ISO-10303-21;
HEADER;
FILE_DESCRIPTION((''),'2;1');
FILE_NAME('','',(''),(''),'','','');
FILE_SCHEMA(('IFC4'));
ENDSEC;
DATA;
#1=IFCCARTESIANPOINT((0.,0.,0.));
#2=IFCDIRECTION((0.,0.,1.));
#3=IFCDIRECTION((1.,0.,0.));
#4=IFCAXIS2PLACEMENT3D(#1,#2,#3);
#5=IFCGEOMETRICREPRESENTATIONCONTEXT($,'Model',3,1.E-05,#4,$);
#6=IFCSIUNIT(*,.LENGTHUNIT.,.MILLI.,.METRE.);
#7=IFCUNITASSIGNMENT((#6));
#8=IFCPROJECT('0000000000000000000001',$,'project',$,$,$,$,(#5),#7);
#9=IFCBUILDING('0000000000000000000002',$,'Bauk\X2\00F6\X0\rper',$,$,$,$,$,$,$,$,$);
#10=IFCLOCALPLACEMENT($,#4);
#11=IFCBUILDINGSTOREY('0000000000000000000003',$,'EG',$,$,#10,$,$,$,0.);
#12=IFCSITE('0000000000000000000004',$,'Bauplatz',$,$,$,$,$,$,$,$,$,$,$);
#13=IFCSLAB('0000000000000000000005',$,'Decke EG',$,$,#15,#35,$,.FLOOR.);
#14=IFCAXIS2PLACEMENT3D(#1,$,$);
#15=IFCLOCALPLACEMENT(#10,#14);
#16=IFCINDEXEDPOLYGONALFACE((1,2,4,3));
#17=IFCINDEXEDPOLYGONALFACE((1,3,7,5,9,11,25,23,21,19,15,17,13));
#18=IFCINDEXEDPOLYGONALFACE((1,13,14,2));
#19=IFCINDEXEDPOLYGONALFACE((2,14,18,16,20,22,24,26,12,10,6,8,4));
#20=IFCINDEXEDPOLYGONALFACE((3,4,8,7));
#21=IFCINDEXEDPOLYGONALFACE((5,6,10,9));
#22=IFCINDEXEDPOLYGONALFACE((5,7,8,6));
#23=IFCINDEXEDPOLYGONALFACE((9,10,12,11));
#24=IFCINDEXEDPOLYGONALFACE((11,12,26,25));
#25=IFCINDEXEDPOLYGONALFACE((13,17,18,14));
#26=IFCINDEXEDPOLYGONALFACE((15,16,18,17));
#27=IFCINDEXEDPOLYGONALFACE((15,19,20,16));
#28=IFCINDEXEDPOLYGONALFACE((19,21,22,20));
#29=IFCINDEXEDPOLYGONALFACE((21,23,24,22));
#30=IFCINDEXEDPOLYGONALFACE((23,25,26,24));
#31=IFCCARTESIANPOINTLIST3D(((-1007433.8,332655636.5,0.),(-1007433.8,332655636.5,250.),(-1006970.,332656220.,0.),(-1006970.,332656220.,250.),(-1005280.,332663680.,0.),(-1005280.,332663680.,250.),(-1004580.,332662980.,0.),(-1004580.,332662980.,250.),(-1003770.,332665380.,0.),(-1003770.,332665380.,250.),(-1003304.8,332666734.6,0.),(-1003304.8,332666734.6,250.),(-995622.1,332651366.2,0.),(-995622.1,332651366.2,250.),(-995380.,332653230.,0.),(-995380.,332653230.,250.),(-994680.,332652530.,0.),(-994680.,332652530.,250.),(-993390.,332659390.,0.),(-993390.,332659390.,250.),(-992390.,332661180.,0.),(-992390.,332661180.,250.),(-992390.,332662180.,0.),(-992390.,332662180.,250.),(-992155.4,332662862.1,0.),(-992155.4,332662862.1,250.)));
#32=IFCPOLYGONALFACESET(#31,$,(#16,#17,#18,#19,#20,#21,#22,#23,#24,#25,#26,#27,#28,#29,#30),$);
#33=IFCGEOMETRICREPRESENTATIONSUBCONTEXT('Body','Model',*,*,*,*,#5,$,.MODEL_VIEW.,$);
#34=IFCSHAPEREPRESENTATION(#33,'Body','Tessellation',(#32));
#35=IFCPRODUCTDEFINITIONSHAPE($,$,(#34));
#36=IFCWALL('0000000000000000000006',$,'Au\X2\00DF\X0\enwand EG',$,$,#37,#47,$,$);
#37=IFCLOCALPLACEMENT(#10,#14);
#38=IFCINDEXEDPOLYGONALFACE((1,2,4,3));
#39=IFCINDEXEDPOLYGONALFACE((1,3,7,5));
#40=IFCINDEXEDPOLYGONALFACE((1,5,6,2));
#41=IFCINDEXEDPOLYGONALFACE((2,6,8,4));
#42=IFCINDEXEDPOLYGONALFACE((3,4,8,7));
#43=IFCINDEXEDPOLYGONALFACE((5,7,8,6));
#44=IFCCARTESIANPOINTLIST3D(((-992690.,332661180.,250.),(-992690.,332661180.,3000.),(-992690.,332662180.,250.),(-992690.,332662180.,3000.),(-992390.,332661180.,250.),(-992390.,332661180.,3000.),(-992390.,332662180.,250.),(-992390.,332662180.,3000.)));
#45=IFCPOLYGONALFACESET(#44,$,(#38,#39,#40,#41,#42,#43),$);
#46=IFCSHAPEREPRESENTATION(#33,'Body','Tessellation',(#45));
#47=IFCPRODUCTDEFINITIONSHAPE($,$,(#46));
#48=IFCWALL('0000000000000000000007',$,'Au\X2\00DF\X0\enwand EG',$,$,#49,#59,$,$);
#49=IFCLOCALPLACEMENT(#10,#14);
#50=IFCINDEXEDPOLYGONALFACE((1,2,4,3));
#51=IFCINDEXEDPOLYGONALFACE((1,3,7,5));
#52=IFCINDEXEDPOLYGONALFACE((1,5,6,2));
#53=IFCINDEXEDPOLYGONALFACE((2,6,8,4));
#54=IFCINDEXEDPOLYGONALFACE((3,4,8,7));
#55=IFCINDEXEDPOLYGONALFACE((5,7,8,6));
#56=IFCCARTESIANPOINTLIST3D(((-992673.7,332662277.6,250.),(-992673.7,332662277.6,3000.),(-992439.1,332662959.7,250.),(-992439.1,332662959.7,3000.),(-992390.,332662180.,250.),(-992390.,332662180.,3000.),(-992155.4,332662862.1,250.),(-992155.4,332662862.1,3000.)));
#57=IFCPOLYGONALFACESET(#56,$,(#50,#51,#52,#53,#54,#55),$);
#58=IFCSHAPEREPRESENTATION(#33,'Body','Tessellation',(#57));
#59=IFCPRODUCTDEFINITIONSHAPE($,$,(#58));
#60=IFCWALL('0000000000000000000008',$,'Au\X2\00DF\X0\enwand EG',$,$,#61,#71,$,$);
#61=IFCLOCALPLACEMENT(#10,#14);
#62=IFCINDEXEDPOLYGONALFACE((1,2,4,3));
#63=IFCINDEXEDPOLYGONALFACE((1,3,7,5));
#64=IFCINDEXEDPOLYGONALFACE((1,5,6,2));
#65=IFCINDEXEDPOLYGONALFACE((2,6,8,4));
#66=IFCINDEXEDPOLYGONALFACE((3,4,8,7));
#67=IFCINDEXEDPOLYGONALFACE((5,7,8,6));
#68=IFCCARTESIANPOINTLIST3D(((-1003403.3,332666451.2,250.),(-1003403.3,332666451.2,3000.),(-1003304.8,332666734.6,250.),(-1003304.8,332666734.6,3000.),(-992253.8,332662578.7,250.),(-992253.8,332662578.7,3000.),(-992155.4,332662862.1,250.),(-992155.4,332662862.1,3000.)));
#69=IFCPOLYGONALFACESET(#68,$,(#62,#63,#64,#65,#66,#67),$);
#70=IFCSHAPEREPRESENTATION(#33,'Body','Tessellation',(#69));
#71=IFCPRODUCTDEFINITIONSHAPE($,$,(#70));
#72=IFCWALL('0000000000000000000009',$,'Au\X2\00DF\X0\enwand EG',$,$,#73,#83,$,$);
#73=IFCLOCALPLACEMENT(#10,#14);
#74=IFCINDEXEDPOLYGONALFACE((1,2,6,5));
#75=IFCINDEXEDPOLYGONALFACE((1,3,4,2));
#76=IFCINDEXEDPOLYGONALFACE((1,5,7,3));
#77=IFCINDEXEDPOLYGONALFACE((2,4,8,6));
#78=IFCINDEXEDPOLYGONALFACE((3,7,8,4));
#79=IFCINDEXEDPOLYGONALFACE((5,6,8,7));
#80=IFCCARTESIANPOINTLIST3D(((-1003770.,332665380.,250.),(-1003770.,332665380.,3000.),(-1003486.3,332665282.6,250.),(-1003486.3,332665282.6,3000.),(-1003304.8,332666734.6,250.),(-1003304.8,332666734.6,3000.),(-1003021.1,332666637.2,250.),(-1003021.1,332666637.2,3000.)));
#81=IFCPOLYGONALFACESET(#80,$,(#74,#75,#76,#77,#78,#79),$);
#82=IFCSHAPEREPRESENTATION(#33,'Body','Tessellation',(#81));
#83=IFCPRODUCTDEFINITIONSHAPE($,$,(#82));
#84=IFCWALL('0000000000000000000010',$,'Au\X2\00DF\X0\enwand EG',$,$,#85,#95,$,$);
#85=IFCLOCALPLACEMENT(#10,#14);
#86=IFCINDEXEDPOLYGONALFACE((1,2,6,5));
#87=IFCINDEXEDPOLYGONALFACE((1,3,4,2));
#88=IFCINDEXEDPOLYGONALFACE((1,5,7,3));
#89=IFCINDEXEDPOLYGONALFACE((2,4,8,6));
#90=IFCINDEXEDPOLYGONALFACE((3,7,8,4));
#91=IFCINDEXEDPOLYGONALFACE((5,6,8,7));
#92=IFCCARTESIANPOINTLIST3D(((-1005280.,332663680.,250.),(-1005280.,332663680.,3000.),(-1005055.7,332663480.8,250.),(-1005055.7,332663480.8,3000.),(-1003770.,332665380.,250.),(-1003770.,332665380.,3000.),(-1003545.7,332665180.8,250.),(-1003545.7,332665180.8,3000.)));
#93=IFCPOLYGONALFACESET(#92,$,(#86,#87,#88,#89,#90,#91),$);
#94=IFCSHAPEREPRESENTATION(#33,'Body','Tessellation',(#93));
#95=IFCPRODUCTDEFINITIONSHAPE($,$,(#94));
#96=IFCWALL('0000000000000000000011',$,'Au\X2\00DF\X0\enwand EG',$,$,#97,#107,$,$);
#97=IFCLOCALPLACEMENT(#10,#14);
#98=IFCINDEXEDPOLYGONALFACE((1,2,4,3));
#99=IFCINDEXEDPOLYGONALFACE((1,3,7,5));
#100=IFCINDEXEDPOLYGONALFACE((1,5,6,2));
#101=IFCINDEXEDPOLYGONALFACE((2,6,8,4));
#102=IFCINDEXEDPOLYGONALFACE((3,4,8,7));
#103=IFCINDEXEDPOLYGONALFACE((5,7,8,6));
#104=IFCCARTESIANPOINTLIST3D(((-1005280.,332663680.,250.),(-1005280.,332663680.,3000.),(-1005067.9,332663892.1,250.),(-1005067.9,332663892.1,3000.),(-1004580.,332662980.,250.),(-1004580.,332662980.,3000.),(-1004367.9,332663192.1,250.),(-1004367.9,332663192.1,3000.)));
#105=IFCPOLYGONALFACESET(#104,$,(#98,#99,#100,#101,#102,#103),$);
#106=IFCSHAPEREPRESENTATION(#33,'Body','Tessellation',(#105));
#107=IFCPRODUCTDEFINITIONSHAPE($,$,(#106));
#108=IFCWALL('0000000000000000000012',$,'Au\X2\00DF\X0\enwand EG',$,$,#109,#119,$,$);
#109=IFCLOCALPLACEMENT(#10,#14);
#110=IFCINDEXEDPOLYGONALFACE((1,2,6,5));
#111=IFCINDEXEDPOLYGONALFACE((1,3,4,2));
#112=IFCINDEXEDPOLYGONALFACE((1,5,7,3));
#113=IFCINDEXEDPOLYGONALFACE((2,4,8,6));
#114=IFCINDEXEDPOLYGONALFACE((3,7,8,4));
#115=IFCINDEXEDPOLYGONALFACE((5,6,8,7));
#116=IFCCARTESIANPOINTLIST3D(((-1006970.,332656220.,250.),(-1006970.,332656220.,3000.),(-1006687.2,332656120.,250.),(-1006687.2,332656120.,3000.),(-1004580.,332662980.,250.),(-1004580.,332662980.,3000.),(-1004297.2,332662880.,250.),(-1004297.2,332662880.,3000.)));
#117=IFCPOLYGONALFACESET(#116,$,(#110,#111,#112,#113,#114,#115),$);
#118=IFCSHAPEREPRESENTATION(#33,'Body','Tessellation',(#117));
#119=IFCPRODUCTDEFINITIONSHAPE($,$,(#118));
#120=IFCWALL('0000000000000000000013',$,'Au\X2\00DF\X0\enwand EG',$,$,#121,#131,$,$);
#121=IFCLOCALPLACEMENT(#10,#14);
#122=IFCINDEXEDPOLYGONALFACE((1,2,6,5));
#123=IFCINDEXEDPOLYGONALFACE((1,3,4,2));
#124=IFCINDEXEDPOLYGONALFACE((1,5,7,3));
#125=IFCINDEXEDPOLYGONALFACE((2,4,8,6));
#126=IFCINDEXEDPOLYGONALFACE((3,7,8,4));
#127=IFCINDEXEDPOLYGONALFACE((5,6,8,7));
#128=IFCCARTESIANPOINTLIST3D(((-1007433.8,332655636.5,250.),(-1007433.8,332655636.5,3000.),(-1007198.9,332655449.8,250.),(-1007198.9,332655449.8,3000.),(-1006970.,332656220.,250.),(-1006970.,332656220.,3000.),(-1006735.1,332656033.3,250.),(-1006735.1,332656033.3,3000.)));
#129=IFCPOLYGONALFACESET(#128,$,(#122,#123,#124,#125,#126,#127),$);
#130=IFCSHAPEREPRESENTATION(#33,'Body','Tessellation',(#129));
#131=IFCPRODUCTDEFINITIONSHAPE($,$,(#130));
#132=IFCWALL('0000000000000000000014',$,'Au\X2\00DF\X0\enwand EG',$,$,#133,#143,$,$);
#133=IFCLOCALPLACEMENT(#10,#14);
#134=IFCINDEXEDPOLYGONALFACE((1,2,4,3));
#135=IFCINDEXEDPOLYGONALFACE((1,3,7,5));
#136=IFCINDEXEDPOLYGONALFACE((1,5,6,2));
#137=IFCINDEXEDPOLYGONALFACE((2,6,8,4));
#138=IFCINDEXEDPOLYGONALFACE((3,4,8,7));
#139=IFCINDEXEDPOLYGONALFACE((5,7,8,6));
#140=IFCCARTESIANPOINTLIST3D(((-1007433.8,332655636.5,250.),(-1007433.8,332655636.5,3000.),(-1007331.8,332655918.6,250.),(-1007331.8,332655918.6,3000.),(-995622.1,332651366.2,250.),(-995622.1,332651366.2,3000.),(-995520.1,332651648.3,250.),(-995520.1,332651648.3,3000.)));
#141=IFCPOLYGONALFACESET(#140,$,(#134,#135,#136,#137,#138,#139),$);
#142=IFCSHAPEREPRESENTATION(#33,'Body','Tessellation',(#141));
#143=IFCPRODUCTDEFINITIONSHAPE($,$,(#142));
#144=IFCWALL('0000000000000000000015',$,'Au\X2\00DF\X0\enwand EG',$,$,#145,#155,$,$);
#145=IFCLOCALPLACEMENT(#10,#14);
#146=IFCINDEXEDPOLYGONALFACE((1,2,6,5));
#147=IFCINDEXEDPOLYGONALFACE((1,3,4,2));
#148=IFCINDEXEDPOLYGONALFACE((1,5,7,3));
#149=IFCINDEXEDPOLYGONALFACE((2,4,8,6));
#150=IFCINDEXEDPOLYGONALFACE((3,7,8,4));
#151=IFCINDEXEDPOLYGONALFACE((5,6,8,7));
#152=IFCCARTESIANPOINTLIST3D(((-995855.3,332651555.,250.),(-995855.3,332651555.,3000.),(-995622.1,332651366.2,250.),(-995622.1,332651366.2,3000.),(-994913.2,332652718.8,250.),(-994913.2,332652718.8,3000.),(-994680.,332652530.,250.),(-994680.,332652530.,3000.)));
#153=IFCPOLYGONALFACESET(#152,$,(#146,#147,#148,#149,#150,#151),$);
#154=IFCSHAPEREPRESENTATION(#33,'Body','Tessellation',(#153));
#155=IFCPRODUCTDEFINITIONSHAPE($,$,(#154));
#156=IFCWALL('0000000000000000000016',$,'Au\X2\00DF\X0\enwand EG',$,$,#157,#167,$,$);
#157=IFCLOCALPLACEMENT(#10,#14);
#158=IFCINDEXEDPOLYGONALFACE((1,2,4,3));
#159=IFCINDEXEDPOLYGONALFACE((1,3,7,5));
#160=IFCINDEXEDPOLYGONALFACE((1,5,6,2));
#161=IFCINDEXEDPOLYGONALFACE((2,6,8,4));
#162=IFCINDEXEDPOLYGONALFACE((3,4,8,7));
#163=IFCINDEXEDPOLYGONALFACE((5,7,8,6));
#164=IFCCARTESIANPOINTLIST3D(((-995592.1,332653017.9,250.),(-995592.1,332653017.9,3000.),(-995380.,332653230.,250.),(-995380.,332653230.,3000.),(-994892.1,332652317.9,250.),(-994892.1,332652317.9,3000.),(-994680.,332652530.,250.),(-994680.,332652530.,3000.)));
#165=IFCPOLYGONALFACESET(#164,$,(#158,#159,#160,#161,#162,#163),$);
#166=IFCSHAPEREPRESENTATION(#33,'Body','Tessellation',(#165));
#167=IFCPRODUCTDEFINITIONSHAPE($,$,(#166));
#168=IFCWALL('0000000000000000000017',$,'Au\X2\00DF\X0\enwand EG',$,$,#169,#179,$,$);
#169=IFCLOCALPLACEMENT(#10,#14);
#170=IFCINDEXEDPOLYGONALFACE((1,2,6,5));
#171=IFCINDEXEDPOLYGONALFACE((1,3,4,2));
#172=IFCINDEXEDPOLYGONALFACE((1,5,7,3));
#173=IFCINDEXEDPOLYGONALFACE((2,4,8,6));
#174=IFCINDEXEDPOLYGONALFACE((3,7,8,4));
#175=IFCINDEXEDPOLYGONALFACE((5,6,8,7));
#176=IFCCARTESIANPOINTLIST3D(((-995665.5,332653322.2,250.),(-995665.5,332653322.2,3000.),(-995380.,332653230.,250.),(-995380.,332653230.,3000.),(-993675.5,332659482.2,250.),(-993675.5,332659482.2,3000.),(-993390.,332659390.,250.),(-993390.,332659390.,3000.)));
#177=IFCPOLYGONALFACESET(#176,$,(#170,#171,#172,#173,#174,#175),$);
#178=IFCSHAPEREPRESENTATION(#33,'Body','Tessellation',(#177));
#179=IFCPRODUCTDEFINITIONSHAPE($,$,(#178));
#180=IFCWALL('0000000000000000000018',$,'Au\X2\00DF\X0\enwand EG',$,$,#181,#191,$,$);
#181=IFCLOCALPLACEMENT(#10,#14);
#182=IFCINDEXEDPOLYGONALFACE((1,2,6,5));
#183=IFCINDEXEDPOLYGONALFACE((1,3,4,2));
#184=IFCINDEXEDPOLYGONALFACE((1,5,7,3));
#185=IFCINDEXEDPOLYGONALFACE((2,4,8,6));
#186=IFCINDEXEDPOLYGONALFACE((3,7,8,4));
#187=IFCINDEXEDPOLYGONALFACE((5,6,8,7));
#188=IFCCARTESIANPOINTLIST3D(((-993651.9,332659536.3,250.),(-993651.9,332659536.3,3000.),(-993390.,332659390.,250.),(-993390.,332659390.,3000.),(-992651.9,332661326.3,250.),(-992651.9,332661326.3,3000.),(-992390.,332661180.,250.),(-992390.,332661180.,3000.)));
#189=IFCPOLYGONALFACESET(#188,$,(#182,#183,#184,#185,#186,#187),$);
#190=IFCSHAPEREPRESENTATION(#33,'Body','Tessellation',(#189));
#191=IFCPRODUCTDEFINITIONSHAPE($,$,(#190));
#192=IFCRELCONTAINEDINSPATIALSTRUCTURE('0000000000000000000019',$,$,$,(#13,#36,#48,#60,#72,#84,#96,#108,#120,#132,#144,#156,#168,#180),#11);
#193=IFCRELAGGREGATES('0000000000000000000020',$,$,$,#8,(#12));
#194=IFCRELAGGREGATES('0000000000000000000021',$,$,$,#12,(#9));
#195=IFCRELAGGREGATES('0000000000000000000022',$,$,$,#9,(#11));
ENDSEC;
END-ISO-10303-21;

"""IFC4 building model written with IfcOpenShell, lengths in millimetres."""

from ifc_helpers import new_model, si_unit, frame, origin_with_axes, place, context, subcontext, project, spatial, indexed_curve, outline, extrude, element, save


model = new_model("IFC4")

# Units and contexts
model_context = context("Model", 3, precision=1e-05, world=origin_with_axes())
body_context = subcontext(model_context, "Body", "Model", "MODEL_VIEW")
ifc_project = project(units=[si_unit("LENGTHUNIT", "METRE", prefix="MILLI")], contexts=[model_context])

# Site, building, storey
site = spatial("IfcSite", under=ifc_project, Name="Bauplatz")
building = spatial("IfcBuilding", under=site, Name="Baukörper")
storey_placement = place(None, origin_with_axes())
storey = spatial("IfcBuildingStorey", under=building, at=storey_placement, Name="EG", Elevation=0.0)

# Slab
slab_placement = place(storey_placement, origin_with_axes())
element("IfcSlab", 1, at=slab_placement, inside=storey, Name="Decke EG", PredefinedType="FLOOR", context=body_context, shape_type="SweptSolid", body=[
    extrude(outline(indexed_curve([(-992390.0, 332661180.0), (-993390.0, 332659390.0), (-995380.0, 332653230.0), (-994680.0, 332652530.0), (-995622.1, 332651366.2), (-1007433.8, 332655636.5), (-1006970.0, 332656220.0), (-1004580.0, 332662980.0), (-1005280.0, 332663680.0), (-1003770.0, 332665380.0), (-1003304.8, 332666734.6), (-992155.4, 332662862.1), (-992390.0, 332662180.0)])), None, (0.0, 0.0, 1.0), 250.0),
])

# Walls
wall_1_placement = place(storey_placement, frame((-992390.0, 332661180.0, 250.0), z_axis=(0.0, 0.0, 1.0), x_axis=(0.0, 1.0, 0.0)))
element("IfcWall", 2, at=wall_1_placement, inside=storey, Name="Außenwand EG", context=body_context, shape_type="SweptSolid", body=[
    extrude(outline(indexed_curve([(0.0, 0.0), (0.0, 300.0), (1000.0, 300.0), (1000.0, 0.0), (0.0, 0.0)], self_intersect=False)), origin_with_axes(), (0.0, 0.0, 1.0), 2750.0),
])
wall_2_placement = place(storey_placement, frame((-992390.0, 332662180.0, 250.0), z_axis=(0.0, 0.0, 1.0), x_axis=(0.32522, 0.945639, 0.0)))
element("IfcWall", 3, at=wall_2_placement, inside=storey, Name="Außenwand EG", context=body_context, shape_type="SweptSolid", body=[
    extrude(outline(indexed_curve([(0.0, 0.0), (0.0, 300.0), (721.3, 300.0), (721.3, 0.0), (0.0, 0.0)], self_intersect=False)), origin_with_axes(), (0.0, 0.0, 1.0), 2750.0),
])
wall_3_placement = place(storey_placement, frame((-992155.4, 332662862.1, 250.0), z_axis=(0.0, 0.0, 1.0), x_axis=(-0.944643, 0.328101, 0.0)))
element("IfcWall", 4, at=wall_3_placement, inside=storey, Name="Außenwand EG", context=body_context, shape_type="SweptSolid", body=[
    extrude(outline(indexed_curve([(0.0, 0.0), (0.0, 300.0), (11802.8, 300.0), (11802.8, 0.0), (0.0, 0.0)], self_intersect=False)), origin_with_axes(), (0.0, 0.0, 1.0), 2750.0),
])
wall_4_placement = place(storey_placement, frame((-1003304.8, 332666734.6, 250.0), z_axis=(0.0, 0.0, 1.0), x_axis=(-0.324776, -0.945791, 0.0)))
element("IfcWall", 5, at=wall_4_placement, inside=storey, Name="Außenwand EG", context=body_context, shape_type="SweptSolid", body=[
    extrude(outline(indexed_curve([(0.0, 0.0), (0.0, 300.0), (1432.3, 300.0), (1432.3, 0.0), (0.0, 0.0)], self_intersect=False)), origin_with_axes(), (0.0, 0.0, 1.0), 2750.0),
])
wall_5_placement = place(storey_placement, frame((-1003770.0, 332665380.0, 250.0), z_axis=(0.0, 0.0, 1.0), x_axis=(-0.664091, -0.747652, 0.0)))
element("IfcWall", 6, at=wall_5_placement, inside=storey, Name="Außenwand EG", context=body_context, shape_type="SweptSolid", body=[
    extrude(outline(indexed_curve([(0.0, 0.0), (0.0, 300.0), (2273.8, 300.0), (2273.8, 0.0), (0.0, 0.0)], self_intersect=False)), origin_with_axes(), (0.0, 0.0, 1.0), 2750.0),
])
wall_6_placement = place(storey_placement, frame((-1005280.0, 332663680.0, 250.0), z_axis=(0.0, 0.0, 1.0), x_axis=(0.707107, -0.707107, 0.0)))
element("IfcWall", 7, at=wall_6_placement, inside=storey, Name="Außenwand EG", context=body_context, shape_type="SweptSolid", body=[
    extrude(outline(indexed_curve([(0.0, 0.0), (0.0, 300.0), (989.9, 300.0), (989.9, 0.0), (0.0, 0.0)], self_intersect=False)), origin_with_axes(), (0.0, 0.0, 1.0), 2750.0),
])
wall_7_placement = place(storey_placement, frame((-1004580.0, 332662980.0, 250.0), z_axis=(0.0, 0.0, 1.0), x_axis=(-0.333331, -0.94281, 0.0)))
element("IfcWall", 8, at=wall_7_placement, inside=storey, Name="Außenwand EG", context=body_context, shape_type="SweptSolid", body=[
    extrude(outline(indexed_curve([(0.0, 0.0), (0.0, 300.0), (7170.1, 300.0), (7170.1, 0.0), (0.0, 0.0)], self_intersect=False)), origin_with_axes(), (0.0, 0.0, 1.0), 2750.0),
])
wall_8_placement = place(storey_placement, frame((-1006970.0, 332656220.0, 250.0), z_axis=(0.0, 0.0, 1.0), x_axis=(-0.622179, -0.782875, 0.0)))
element("IfcWall", 9, at=wall_8_placement, inside=storey, Name="Außenwand EG", context=body_context, shape_type="SweptSolid", body=[
    extrude(outline(indexed_curve([(0.0, 0.0), (0.0, 300.0), (745.4, 300.0), (745.4, 0.0), (0.0, 0.0)], self_intersect=False)), origin_with_axes(), (0.0, 0.0, 1.0), 2750.0),
])
wall_9_placement = place(storey_placement, frame((-1007433.8, 332655636.5, 250.0), z_axis=(0.0, 0.0, 1.0), x_axis=(0.940428, -0.339993, 0.0)))
element("IfcWall", 10, at=wall_9_placement, inside=storey, Name="Außenwand EG", context=body_context, shape_type="SweptSolid", body=[
    extrude(outline(indexed_curve([(0.0, 0.0), (0.0, 300.0), (12559.9, 300.0), (12559.9, 0.0), (0.0, 0.0)], self_intersect=False)), origin_with_axes(), (0.0, 0.0, 1.0), 2750.0),
])
wall_10_placement = place(storey_placement, frame((-995622.1, 332651366.2, 250.0), z_axis=(0.0, 0.0, 1.0), x_axis=(0.629198, 0.777245, 0.0)))
element("IfcWall", 11, at=wall_10_placement, inside=storey, Name="Außenwand EG", context=body_context, shape_type="SweptSolid", body=[
    extrude(outline(indexed_curve([(0.0, 0.0), (0.0, 300.0), (1497.3, 300.0), (1497.3, 0.0), (0.0, 0.0)], self_intersect=False)), origin_with_axes(), (0.0, 0.0, 1.0), 2750.0),
])
wall_11_placement = place(storey_placement, frame((-994680.0, 332652530.0, 250.0), z_axis=(0.0, 0.0, 1.0), x_axis=(-0.707107, 0.707107, 0.0)))
element("IfcWall", 12, at=wall_11_placement, inside=storey, Name="Außenwand EG", context=body_context, shape_type="SweptSolid", body=[
    extrude(outline(indexed_curve([(0.0, 0.0), (0.0, 300.0), (989.9, 300.0), (989.9, 0.0), (0.0, 0.0)], self_intersect=False)), origin_with_axes(), (0.0, 0.0, 1.0), 2750.0),
])
wall_12_placement = place(storey_placement, frame((-995380.0, 332653230.0, 250.0), z_axis=(0.0, 0.0, 1.0), x_axis=(0.307409, 0.951577, 0.0)))
element("IfcWall", 13, at=wall_12_placement, inside=storey, Name="Außenwand EG", context=body_context, shape_type="SweptSolid", body=[
    extrude(outline(indexed_curve([(0.0, 0.0), (0.0, 300.0), (6473.5, 300.0), (6473.5, 0.0), (0.0, 0.0)], self_intersect=False)), origin_with_axes(), (0.0, 0.0, 1.0), 2750.0),
])
wall_13_placement = place(storey_placement, frame((-993390.0, 332659390.0, 250.0), z_axis=(0.0, 0.0, 1.0), x_axis=(0.487712, 0.873005, 0.0)))
element("IfcWall", 14, at=wall_13_placement, inside=storey, Name="Außenwand EG", context=body_context, shape_type="SweptSolid", body=[
    extrude(outline(indexed_curve([(0.0, 0.0), (0.0, 300.0), (2050.4, 300.0), (2050.4, 0.0), (0.0, 0.0)], self_intersect=False)), origin_with_axes(), (0.0, 0.0, 1.0), 2750.0),
])

save(model, "model.ifc")
